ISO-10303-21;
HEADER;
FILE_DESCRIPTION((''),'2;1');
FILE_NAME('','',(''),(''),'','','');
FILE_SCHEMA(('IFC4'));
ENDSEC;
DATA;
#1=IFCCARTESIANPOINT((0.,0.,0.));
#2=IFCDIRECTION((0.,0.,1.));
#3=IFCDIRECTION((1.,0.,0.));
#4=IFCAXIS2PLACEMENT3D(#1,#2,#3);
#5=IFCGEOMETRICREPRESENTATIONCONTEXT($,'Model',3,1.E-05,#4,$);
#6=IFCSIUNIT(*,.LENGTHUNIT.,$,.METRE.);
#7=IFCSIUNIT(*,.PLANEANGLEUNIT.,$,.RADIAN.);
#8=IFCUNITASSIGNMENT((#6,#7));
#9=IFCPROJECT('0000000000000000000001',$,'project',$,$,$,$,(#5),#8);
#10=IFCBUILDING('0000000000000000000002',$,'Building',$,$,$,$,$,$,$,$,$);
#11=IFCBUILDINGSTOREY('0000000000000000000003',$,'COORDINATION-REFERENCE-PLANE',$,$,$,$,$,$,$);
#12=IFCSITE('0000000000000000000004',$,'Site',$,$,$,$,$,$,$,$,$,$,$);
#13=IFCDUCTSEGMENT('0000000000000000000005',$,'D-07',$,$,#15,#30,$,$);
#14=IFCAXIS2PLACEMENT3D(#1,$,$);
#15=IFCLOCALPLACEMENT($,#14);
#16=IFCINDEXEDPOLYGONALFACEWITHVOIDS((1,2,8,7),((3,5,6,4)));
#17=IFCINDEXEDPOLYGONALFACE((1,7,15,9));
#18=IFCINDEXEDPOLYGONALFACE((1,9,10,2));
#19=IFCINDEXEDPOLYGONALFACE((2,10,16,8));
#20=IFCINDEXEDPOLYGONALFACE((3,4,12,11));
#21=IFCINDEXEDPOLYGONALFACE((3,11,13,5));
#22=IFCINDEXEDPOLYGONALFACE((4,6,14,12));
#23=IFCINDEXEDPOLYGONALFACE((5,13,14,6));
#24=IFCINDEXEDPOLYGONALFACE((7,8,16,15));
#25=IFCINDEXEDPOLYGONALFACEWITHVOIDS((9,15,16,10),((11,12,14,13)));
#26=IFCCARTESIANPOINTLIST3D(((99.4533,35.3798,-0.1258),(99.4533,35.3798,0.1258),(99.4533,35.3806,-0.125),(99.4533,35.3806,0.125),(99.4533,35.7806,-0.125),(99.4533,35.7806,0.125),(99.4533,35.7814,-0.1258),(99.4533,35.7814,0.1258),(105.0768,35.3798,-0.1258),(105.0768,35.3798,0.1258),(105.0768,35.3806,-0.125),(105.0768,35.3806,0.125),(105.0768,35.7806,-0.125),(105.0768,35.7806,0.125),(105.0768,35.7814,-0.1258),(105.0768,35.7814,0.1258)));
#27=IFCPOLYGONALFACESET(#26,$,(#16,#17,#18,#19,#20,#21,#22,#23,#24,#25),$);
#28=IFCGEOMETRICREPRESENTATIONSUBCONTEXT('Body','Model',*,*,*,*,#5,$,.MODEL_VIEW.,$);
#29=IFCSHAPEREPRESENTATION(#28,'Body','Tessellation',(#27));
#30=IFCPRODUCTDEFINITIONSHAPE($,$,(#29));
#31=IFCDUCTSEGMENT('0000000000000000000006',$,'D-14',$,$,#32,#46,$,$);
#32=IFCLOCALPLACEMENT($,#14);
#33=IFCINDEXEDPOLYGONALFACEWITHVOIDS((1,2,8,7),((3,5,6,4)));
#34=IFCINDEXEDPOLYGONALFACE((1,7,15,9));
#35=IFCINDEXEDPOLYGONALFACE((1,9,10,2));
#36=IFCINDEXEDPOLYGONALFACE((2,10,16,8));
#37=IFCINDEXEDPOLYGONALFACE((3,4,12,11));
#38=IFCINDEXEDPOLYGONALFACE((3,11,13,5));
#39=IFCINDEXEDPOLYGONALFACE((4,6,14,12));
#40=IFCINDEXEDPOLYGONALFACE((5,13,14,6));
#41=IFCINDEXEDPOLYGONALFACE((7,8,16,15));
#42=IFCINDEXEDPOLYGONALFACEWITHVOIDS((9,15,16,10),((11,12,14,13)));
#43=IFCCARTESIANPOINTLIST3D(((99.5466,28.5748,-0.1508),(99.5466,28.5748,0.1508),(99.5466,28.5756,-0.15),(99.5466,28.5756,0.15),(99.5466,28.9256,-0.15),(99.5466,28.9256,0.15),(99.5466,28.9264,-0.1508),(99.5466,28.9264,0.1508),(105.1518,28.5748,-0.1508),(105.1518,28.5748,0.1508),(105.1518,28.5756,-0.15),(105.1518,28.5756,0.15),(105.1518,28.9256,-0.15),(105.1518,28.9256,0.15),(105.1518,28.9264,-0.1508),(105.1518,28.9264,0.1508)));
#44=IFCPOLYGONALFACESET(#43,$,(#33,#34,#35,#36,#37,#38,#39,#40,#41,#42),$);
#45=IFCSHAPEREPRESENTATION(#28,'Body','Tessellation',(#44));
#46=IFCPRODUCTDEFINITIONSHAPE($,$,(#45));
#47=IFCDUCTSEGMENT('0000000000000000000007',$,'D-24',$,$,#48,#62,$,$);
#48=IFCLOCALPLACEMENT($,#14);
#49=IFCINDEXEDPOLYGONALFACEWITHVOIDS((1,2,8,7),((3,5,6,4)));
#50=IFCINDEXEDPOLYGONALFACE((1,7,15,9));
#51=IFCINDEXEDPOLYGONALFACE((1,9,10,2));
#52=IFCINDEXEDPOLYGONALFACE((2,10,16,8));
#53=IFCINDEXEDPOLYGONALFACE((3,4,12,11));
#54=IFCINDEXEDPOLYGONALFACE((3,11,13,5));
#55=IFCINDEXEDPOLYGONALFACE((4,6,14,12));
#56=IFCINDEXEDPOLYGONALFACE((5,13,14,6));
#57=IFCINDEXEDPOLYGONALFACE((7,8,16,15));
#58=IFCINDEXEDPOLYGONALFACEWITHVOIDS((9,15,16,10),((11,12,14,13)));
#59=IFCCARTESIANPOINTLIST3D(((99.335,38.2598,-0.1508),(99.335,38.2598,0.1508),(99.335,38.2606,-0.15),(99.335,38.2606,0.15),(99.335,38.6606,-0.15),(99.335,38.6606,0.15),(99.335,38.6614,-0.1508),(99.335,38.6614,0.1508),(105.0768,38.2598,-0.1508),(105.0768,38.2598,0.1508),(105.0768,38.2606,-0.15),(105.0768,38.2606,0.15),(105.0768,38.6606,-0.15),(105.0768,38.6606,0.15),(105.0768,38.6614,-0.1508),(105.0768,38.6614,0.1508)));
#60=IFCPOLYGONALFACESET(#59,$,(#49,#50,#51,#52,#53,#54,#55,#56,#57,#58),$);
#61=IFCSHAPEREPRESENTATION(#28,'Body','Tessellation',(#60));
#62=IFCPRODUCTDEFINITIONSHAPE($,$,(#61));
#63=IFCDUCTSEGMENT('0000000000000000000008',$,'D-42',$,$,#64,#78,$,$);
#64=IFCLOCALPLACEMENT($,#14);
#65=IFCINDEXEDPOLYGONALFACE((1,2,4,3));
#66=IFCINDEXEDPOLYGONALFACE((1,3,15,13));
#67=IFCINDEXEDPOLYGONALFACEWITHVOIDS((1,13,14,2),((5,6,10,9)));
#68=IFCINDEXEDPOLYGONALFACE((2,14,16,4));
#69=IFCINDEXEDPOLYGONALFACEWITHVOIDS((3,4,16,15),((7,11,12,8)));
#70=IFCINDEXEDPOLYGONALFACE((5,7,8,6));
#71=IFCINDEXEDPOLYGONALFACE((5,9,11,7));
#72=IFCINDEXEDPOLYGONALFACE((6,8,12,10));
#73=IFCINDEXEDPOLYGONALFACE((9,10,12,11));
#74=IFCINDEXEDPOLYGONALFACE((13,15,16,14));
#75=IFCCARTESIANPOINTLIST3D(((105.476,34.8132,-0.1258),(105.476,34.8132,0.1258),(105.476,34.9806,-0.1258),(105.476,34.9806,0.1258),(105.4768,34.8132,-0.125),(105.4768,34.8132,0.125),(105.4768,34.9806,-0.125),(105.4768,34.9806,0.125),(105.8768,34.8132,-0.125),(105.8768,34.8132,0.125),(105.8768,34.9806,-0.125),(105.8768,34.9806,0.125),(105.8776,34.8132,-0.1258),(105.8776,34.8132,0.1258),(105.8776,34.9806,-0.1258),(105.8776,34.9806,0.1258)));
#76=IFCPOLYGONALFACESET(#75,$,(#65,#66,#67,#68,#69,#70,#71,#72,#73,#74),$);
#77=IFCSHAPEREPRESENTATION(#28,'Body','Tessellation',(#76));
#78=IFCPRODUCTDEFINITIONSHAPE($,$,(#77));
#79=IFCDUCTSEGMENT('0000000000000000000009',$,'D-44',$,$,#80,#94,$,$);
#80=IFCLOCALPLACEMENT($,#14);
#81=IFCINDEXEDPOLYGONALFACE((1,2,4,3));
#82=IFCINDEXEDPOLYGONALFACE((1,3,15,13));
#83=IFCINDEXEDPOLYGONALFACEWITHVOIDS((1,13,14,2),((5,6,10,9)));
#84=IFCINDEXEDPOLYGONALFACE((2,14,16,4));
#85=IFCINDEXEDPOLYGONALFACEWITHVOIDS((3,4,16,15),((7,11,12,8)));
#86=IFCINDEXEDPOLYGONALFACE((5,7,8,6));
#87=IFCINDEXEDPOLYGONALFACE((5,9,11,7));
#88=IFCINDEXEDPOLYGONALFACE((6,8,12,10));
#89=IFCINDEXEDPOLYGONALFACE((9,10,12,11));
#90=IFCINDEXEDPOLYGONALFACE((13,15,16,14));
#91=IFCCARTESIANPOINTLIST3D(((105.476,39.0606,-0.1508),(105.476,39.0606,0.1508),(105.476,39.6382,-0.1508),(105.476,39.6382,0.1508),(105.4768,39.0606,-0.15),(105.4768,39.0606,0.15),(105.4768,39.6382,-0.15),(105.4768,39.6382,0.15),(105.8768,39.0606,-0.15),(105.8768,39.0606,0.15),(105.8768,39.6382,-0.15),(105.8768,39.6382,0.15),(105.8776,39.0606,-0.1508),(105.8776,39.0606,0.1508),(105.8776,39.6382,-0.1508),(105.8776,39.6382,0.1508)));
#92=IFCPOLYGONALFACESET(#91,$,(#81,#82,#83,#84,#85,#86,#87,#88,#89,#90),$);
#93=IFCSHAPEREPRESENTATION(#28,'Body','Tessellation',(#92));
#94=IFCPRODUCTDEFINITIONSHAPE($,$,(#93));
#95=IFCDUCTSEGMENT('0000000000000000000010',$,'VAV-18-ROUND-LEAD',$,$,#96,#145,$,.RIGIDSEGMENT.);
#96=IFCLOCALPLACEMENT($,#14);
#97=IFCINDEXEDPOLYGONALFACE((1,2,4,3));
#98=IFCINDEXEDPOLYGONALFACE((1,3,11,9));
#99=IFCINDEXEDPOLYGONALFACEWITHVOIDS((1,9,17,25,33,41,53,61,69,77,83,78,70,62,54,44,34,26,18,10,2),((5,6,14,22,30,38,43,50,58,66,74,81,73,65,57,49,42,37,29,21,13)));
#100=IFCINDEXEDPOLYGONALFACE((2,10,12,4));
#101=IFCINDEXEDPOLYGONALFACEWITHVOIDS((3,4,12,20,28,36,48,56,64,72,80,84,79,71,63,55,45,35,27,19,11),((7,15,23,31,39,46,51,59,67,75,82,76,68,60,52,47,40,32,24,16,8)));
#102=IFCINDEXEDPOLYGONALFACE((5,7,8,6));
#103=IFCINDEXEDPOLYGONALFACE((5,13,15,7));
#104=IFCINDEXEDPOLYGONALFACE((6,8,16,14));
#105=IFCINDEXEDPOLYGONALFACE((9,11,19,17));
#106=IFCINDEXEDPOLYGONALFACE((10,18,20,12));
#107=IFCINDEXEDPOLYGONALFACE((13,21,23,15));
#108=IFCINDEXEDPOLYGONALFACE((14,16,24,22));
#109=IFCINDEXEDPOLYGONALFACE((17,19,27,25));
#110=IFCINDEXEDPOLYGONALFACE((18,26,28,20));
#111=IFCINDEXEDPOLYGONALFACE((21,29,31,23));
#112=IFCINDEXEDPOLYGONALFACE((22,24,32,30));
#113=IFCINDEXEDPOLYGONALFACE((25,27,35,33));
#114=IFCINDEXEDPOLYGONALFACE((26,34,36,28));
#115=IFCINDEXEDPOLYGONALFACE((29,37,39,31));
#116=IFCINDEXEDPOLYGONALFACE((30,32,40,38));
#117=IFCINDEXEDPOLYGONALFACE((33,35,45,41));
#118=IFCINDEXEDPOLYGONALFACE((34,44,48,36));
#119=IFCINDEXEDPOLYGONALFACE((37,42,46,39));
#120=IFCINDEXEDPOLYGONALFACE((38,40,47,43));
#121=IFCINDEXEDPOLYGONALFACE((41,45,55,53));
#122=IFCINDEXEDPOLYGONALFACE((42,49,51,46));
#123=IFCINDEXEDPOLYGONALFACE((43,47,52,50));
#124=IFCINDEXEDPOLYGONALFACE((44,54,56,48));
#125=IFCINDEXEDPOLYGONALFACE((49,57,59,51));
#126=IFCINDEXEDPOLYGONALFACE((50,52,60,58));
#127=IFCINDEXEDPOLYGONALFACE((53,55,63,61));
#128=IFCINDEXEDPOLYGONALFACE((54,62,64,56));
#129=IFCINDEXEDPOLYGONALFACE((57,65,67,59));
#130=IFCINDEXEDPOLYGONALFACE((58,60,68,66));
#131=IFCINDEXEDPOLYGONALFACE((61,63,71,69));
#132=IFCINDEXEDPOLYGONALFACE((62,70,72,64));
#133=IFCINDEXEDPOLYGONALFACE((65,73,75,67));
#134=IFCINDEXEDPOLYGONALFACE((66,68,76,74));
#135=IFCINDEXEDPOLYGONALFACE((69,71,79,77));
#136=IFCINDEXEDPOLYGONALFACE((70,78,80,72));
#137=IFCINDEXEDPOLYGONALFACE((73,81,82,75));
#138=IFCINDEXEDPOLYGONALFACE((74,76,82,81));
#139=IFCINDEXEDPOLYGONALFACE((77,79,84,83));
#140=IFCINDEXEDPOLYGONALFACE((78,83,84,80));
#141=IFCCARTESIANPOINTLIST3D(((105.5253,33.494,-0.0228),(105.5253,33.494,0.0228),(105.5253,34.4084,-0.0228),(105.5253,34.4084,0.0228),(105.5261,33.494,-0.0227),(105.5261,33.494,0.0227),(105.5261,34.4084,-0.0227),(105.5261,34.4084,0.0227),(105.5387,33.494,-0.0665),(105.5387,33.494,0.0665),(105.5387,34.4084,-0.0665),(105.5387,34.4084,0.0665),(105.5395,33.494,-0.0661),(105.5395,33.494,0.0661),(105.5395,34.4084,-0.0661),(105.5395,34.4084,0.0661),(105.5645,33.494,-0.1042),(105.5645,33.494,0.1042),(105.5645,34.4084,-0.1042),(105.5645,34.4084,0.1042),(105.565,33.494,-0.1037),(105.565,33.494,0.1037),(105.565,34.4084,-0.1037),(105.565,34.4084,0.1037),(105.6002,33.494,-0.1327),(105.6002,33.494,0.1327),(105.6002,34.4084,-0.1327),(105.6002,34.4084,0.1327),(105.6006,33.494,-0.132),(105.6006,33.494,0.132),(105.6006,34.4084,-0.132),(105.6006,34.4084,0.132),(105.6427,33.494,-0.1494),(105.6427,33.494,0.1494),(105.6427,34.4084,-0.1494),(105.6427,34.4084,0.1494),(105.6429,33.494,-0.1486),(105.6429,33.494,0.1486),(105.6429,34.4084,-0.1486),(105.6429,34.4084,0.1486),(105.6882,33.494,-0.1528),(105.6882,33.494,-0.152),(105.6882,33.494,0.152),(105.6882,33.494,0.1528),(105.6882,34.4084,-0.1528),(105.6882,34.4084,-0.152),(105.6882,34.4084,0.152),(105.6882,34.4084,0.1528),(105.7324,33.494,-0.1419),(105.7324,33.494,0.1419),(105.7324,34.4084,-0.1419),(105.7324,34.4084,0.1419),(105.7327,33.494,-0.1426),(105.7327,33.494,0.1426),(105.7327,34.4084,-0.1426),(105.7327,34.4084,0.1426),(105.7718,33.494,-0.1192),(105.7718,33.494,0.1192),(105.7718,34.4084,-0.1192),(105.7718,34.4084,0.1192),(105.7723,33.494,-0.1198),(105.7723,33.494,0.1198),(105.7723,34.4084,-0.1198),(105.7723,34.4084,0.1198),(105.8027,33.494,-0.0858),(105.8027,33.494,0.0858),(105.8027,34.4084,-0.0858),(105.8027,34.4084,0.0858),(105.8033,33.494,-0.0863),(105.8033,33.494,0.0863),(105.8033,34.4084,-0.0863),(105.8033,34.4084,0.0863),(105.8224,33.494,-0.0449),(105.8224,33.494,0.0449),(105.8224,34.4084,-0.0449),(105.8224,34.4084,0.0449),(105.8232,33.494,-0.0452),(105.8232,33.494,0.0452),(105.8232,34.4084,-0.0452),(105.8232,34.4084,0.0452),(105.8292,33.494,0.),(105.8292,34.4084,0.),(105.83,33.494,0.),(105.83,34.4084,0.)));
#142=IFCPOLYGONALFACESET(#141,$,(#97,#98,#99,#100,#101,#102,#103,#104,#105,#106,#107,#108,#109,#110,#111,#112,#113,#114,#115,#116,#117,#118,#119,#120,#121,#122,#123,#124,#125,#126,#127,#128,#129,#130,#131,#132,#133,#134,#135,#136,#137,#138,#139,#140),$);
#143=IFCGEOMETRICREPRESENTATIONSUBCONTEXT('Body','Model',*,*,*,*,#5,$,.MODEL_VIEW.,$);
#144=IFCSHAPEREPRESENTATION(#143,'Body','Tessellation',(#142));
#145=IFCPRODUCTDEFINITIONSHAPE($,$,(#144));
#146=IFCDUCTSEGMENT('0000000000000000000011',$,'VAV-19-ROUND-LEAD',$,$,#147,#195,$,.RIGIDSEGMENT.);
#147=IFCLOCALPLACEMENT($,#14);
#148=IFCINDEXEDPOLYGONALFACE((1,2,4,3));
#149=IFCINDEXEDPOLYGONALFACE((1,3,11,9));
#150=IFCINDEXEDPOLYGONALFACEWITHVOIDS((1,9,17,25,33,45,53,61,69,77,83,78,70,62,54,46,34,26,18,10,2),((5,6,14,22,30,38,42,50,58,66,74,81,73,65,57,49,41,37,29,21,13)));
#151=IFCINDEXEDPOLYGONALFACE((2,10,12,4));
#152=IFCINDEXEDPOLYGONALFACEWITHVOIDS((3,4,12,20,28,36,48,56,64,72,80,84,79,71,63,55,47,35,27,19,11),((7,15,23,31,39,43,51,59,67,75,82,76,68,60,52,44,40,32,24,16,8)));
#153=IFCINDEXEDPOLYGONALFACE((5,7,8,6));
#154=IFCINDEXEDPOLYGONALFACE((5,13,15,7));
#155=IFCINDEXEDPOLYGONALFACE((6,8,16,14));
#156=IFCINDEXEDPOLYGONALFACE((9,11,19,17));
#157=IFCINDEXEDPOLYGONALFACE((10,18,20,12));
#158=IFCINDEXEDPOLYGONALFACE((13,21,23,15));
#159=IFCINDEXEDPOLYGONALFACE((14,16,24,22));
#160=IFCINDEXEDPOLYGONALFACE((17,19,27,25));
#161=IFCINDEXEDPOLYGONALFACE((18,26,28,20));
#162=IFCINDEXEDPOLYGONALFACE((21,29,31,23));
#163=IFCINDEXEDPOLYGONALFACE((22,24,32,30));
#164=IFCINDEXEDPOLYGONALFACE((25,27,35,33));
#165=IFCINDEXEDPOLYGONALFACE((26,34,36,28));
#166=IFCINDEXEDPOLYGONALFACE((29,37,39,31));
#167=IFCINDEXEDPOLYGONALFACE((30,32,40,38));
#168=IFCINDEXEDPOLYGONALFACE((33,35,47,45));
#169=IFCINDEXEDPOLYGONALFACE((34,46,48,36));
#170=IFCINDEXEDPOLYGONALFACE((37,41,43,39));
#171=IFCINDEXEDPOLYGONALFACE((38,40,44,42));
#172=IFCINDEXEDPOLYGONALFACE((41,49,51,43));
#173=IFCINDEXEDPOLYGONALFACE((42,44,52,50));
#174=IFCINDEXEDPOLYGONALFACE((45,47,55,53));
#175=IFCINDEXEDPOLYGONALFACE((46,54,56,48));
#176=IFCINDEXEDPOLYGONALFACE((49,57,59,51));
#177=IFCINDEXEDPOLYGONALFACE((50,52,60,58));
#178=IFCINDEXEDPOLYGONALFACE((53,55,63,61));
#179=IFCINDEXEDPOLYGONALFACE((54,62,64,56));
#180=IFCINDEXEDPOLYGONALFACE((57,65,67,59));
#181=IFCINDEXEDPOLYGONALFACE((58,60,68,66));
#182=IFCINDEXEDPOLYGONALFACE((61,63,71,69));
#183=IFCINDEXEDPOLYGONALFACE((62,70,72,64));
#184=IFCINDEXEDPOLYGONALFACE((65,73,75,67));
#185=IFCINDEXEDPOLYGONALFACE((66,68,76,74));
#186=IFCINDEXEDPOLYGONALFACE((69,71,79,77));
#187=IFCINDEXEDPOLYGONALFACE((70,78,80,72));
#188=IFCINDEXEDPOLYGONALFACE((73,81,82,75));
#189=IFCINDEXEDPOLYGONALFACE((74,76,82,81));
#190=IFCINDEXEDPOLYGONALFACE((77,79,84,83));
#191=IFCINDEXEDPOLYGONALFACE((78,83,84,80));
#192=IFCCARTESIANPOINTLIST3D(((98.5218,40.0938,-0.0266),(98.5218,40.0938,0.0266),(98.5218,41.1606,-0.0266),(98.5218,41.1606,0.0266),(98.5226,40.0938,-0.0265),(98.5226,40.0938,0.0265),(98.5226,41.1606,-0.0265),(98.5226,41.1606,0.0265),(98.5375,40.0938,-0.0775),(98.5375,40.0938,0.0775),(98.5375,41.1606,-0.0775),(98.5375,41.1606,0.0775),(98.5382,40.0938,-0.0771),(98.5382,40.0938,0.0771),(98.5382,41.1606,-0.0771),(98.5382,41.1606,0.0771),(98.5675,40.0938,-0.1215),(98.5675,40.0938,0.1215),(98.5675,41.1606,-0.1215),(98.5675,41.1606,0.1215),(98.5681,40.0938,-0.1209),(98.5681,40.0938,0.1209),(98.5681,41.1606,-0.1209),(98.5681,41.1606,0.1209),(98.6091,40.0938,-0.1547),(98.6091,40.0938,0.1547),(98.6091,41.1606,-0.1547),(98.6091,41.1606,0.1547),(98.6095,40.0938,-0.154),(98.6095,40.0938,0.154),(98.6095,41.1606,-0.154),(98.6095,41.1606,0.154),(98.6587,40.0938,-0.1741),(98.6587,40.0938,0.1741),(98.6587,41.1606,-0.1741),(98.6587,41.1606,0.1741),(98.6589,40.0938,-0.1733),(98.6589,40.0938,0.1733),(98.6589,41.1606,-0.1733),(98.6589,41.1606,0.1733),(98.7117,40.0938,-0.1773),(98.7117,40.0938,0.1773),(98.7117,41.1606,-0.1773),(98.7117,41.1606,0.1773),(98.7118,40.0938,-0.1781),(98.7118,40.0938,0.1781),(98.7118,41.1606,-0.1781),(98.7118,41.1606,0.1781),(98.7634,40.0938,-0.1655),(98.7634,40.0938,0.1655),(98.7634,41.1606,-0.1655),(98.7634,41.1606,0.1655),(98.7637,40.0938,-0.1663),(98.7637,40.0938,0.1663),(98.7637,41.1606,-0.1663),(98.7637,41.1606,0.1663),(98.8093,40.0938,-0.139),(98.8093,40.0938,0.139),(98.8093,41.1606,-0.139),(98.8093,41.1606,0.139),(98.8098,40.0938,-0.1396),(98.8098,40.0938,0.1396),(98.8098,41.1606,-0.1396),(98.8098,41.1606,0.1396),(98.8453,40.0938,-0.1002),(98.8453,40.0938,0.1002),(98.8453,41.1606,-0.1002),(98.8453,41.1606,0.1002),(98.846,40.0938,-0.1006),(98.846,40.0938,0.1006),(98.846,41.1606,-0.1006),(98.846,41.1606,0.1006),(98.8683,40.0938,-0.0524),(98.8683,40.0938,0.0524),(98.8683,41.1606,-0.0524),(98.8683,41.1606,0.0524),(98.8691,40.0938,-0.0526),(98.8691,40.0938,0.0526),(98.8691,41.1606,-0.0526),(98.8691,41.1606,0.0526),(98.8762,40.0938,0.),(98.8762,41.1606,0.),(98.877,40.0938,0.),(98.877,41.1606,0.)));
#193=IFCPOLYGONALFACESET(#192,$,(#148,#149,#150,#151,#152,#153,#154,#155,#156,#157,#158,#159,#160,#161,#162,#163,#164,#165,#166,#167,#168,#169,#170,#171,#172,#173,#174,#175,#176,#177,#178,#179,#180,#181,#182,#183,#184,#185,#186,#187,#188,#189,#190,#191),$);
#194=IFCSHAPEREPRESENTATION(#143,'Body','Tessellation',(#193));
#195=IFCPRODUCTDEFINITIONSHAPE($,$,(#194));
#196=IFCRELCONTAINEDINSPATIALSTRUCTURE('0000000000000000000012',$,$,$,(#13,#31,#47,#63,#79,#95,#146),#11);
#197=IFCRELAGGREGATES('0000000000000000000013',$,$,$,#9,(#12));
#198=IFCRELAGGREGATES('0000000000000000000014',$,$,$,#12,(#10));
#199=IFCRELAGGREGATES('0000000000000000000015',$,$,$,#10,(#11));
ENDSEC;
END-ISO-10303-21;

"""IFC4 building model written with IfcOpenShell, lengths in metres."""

from ifc_helpers import new_model, si_unit, frame, origin, origin_with_axes, place, context, subcontext, project, spatial, hollow_rectangle, hollow_circle, extrude, element, save


model = new_model("IFC4")

# Units and contexts
model_context = context("Model", 3, precision=1e-05, world=origin_with_axes())
body_context_1 = subcontext(model_context, "Body", "Model", "MODEL_VIEW")
body_context_2 = subcontext(model_context, "Body", "Model", "MODEL_VIEW")
ifc_project = project(units=[si_unit("LENGTHUNIT", "METRE"), si_unit("PLANEANGLEUNIT", "RADIAN")], contexts=[model_context])

# Site, building, storey
site = spatial("IfcSite", under=ifc_project, Name="Site")
building = spatial("IfcBuilding", under=site, Name="Building")
storey = spatial("IfcBuildingStorey", under=building, Name="COORDINATION-REFERENCE-PLANE")

# Duct segments
duct_segment_1_placement = place(None, frame((99.4533, 35.5806, 0.0), z_axis=(1.0, 0.0, 0.0), x_axis=(0.0, 1.0, 0.0)))
element("IfcDuctSegment", 1, at=duct_segment_1_placement, inside=storey, Name="D-07", context=body_context_1, shape_type="SweptSolid", body=[
    extrude(hollow_rectangle(XDim=0.4016, YDim=0.2516, WallThickness=0.0008), origin(), (0.0, 0.0, 1.0), 5.6234),
])
duct_segment_2_placement = place(None, frame((99.5466, 28.7506, 0.0), z_axis=(1.0, 0.0, 0.0), x_axis=(0.0, 1.0, 0.0)))
element("IfcDuctSegment", 2, at=duct_segment_2_placement, inside=storey, Name="D-14", context=body_context_1, shape_type="SweptSolid", body=[
    extrude(hollow_rectangle(XDim=0.3516, YDim=0.3016, WallThickness=0.0008), origin(), (0.0, 0.0, 1.0), 5.6051),
])
duct_segment_3_placement = place(None, frame((99.335, 38.4606, 0.0), z_axis=(1.0, 0.0, 0.0), x_axis=(0.0, 1.0, 0.0)))
element("IfcDuctSegment", 3, at=duct_segment_3_placement, inside=storey, Name="D-24", context=body_context_1, shape_type="SweptSolid", body=[
    extrude(hollow_rectangle(XDim=0.4016, YDim=0.3016, WallThickness=0.0008), origin(), (0.0, 0.0, 1.0), 5.7417),
])
duct_segment_4_placement = place(None, frame((105.6768, 34.8132, 0.0), z_axis=(0.0, 1.0, 0.0), x_axis=(1.0, 0.0, 0.0)))
element("IfcDuctSegment", 4, at=duct_segment_4_placement, inside=storey, Name="D-42", context=body_context_1, shape_type="SweptSolid", body=[
    extrude(hollow_rectangle(XDim=0.4016, YDim=0.2516, WallThickness=0.0008), origin(), (0.0, 0.0, 1.0), 0.1673),
])
duct_segment_5_placement = place(None, frame((105.6768, 39.0606, 0.0), z_axis=(0.0, 1.0, 0.0), x_axis=(1.0, 0.0, 0.0)))
element("IfcDuctSegment", 5, at=duct_segment_5_placement, inside=storey, Name="D-44", context=body_context_1, shape_type="SweptSolid", body=[
    extrude(hollow_rectangle(XDim=0.4016, YDim=0.3016, WallThickness=0.0008), origin(), (0.0, 0.0, 1.0), 0.5776),
])

# Duct segments
duct_segment_6_placement = place(None, frame((105.6768, 34.4084, 0.0), z_axis=(0.0, -1.0, 0.0), x_axis=(1.0, 0.0, 0.0)))
element("IfcDuctSegment", 6, at=duct_segment_6_placement, inside=storey, Name="VAV-18-ROUND-LEAD", PredefinedType="RIGIDSEGMENT", context=body_context_2, shape_type="SweptSolid", body=[
    extrude(hollow_circle(Radius=0.1532, WallThickness=0.0008), origin(), (0.0, 0.0, 1.0), 0.9144),
])
for number, where, z_axis, x_axis, name in (
    (7, (98.6984, 40.0938, 0.0), (0.0, 1.0, 0.0), (1.0, 0.0, 0.0), "VAV-19-ROUND-LEAD"),
):
    element("IfcDuctSegment", number, at=place(None, frame(where, z_axis=z_axis, x_axis=x_axis)), inside=storey, Name=name, PredefinedType="RIGIDSEGMENT", context=body_context_2, shape_type="SweptSolid", body=[
        extrude(hollow_circle(Radius=0.1786, WallThickness=0.0008), origin(), (0.0, 0.0, 1.0), 1.0668),
    ])

save(model, "model.ifc")
